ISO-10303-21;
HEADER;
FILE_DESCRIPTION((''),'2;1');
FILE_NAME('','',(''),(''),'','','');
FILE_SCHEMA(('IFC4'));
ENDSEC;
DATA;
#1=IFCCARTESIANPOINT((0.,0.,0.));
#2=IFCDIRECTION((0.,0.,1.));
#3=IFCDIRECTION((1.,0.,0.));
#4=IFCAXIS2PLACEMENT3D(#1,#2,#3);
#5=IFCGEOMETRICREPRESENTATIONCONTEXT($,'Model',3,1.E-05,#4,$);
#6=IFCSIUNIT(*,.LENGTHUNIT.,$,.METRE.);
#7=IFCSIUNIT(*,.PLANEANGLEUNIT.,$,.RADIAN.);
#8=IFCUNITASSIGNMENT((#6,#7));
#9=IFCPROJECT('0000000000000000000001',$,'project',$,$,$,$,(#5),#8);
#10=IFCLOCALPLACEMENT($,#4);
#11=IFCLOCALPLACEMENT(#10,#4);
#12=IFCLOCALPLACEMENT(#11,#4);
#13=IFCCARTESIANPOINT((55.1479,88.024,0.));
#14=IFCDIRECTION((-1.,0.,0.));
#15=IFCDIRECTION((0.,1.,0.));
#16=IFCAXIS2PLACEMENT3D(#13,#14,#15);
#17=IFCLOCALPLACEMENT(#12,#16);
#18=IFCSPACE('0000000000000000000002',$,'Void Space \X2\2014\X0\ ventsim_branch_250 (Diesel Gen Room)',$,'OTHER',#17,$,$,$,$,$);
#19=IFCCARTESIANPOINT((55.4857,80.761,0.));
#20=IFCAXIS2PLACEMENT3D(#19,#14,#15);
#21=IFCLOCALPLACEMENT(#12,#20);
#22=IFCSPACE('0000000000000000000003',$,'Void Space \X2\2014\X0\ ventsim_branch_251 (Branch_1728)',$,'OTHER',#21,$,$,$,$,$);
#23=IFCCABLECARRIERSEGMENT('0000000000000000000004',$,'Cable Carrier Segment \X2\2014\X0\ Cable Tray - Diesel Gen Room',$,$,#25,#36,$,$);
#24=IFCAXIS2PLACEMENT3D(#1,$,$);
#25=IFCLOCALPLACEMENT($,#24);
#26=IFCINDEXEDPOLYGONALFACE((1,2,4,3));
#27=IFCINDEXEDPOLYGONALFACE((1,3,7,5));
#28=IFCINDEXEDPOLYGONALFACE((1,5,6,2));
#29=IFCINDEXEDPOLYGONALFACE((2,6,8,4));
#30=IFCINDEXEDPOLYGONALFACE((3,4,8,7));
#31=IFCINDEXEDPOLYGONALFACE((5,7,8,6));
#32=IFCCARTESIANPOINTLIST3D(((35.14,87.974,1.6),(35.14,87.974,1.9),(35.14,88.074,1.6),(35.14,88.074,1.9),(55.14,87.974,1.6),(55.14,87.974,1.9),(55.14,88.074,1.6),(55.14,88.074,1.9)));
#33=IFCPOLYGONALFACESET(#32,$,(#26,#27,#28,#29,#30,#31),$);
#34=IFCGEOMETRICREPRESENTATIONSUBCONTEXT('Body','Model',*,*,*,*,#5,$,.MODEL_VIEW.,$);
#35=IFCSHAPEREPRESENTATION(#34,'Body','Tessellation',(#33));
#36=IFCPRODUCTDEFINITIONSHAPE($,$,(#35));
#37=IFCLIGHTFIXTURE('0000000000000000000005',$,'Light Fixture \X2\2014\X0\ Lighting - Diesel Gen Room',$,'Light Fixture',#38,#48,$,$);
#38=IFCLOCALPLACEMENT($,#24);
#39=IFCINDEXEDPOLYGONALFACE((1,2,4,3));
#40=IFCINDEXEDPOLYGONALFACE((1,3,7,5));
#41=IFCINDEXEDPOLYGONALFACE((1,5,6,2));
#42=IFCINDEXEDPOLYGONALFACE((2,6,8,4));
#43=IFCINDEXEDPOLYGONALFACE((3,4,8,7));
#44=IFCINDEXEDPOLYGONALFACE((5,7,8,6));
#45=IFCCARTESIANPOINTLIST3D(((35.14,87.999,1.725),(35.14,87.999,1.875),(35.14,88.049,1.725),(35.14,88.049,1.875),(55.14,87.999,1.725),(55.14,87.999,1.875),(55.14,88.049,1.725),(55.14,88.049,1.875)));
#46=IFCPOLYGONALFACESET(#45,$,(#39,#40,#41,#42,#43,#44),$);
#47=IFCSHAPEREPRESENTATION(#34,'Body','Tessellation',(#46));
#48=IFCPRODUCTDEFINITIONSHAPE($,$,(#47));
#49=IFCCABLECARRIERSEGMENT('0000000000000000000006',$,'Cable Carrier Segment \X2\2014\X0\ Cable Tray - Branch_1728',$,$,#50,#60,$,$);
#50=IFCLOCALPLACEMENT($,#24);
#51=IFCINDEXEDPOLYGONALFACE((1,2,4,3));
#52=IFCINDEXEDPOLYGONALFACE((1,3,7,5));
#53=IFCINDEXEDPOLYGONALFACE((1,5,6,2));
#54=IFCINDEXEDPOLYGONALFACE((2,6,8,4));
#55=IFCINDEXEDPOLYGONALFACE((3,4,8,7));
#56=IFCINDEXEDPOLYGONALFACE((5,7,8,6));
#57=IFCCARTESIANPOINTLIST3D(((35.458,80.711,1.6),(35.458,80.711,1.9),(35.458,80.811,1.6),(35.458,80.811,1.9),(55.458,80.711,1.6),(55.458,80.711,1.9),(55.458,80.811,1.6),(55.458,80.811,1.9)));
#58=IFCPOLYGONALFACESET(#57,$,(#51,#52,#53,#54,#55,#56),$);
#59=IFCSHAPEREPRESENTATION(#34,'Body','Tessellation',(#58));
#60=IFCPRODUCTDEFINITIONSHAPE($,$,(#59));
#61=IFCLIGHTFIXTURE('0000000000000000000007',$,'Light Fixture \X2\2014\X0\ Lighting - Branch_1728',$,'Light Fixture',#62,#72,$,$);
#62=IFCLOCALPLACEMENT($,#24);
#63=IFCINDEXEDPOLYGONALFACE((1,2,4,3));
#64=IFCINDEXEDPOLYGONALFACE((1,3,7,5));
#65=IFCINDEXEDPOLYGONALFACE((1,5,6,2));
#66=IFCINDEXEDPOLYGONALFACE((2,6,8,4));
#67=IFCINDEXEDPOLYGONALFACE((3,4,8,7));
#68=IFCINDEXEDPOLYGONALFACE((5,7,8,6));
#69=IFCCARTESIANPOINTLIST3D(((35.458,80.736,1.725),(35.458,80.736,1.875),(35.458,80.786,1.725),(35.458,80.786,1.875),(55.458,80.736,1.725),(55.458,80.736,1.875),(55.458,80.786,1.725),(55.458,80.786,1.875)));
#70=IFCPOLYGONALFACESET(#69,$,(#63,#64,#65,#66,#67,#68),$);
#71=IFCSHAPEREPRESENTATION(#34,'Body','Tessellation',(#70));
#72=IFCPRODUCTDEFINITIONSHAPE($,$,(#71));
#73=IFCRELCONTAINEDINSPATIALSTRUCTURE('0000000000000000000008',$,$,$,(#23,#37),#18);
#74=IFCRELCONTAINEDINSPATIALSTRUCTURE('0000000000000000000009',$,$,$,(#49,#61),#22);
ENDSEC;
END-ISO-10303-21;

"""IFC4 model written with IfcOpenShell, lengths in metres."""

from ifc_helpers import new_model, si_unit, frame, origin_with_axes, origin_2d_with_axis, place, context, subcontext, project, spatial, rectangle, extrude, element, save


model = new_model("IFC4")

# Units and contexts
model_context = context("Model", 3, precision=1e-05, world=origin_with_axes())
body_context = subcontext(model_context, "Body", "Model", "MODEL_VIEW")
ifc_project = project(units=[si_unit("LENGTHUNIT", "METRE"), si_unit("PLANEANGLEUNIT", "RADIAN")], contexts=[model_context])

# Shared definitions
placement_1 = place(None, origin_with_axes())
placement_2 = place(placement_1, origin_with_axes())
placement_3 = place(placement_2, origin_with_axes())

# Shared definitions
space_1_placement = place(placement_3, frame((55.1479, 88.024, 0.0), z_axis=(-1.0, 0.0, 0.0), x_axis=(0.0, 1.0, 0.0)))
space_1 = spatial("IfcSpace", at=space_1_placement, Name="Void Space — ventsim_branch_250 (Diesel Gen Room)", ObjectType="OTHER")

# Cable carrier segment
cable_carrier_segment_1_placement = place(placement_3, frame((55.14, 88.024, 1.75), z_axis=(-1.0, 0.0, 0.0), x_axis=(0.0, 0.0, 1.0)))
element("IfcCableCarrierSegment", 1, at=cable_carrier_segment_1_placement, inside=space_1, Name="Cable Carrier Segment — Cable Tray - Diesel Gen Room", context=body_context, shape_type="SweptSolid", body=[
    extrude(rectangle(XDim=0.3, YDim=0.1, at=origin_2d_with_axis()), origin_with_axes(), (0.0, 0.0, 1.0), 20.0),
])

# Light fixture
light_fixture_1_placement = place(placement_3, frame((55.14, 88.024, 1.8), z_axis=(-1.0, 0.0, 0.0), x_axis=(0.0, 0.0, 1.0)))
element("IfcLightFixture", 2, at=light_fixture_1_placement, inside=space_1, Name="Light Fixture — Lighting - Diesel Gen Room", ObjectType="Light Fixture", context=body_context, shape_type="SweptSolid", body=[
    extrude(rectangle(XDim=0.15, YDim=0.05, at=origin_2d_with_axis()), origin_with_axes(), (0.0, 0.0, 1.0), 20.0),
])

# Shared definitions
space_2_placement = place(placement_3, frame((55.4857, 80.761, 0.0), z_axis=(-1.0, 0.0, 0.0), x_axis=(0.0, 1.0, 0.0)))
space_2 = spatial("IfcSpace", at=space_2_placement, Name="Void Space — ventsim_branch_251 (Branch_1728)", ObjectType="OTHER")

# Cable carrier segment
cable_carrier_segment_2_placement = place(placement_3, frame((55.458, 80.761, 1.75), z_axis=(-1.0, 0.0, 0.0), x_axis=(0.0, 0.0, 1.0)))
element("IfcCableCarrierSegment", 3, at=cable_carrier_segment_2_placement, inside=space_2, Name="Cable Carrier Segment — Cable Tray - Branch_1728", context=body_context, shape_type="SweptSolid", body=[
    extrude(rectangle(XDim=0.3, YDim=0.1, at=origin_2d_with_axis()), origin_with_axes(), (0.0, 0.0, 1.0), 20.0),
])

# Light fixture
light_fixture_2_placement = place(placement_3, frame((55.458, 80.761, 1.8), z_axis=(-1.0, 0.0, 0.0), x_axis=(0.0, 0.0, 1.0)))
element("IfcLightFixture", 4, at=light_fixture_2_placement, inside=space_2, Name="Light Fixture — Lighting - Branch_1728", ObjectType="Light Fixture", context=body_context, shape_type="SweptSolid", body=[
    extrude(rectangle(XDim=0.15, YDim=0.05, at=origin_2d_with_axis()), origin_with_axes(), (0.0, 0.0, 1.0), 20.0),
])

save(model, "model.ifc")
